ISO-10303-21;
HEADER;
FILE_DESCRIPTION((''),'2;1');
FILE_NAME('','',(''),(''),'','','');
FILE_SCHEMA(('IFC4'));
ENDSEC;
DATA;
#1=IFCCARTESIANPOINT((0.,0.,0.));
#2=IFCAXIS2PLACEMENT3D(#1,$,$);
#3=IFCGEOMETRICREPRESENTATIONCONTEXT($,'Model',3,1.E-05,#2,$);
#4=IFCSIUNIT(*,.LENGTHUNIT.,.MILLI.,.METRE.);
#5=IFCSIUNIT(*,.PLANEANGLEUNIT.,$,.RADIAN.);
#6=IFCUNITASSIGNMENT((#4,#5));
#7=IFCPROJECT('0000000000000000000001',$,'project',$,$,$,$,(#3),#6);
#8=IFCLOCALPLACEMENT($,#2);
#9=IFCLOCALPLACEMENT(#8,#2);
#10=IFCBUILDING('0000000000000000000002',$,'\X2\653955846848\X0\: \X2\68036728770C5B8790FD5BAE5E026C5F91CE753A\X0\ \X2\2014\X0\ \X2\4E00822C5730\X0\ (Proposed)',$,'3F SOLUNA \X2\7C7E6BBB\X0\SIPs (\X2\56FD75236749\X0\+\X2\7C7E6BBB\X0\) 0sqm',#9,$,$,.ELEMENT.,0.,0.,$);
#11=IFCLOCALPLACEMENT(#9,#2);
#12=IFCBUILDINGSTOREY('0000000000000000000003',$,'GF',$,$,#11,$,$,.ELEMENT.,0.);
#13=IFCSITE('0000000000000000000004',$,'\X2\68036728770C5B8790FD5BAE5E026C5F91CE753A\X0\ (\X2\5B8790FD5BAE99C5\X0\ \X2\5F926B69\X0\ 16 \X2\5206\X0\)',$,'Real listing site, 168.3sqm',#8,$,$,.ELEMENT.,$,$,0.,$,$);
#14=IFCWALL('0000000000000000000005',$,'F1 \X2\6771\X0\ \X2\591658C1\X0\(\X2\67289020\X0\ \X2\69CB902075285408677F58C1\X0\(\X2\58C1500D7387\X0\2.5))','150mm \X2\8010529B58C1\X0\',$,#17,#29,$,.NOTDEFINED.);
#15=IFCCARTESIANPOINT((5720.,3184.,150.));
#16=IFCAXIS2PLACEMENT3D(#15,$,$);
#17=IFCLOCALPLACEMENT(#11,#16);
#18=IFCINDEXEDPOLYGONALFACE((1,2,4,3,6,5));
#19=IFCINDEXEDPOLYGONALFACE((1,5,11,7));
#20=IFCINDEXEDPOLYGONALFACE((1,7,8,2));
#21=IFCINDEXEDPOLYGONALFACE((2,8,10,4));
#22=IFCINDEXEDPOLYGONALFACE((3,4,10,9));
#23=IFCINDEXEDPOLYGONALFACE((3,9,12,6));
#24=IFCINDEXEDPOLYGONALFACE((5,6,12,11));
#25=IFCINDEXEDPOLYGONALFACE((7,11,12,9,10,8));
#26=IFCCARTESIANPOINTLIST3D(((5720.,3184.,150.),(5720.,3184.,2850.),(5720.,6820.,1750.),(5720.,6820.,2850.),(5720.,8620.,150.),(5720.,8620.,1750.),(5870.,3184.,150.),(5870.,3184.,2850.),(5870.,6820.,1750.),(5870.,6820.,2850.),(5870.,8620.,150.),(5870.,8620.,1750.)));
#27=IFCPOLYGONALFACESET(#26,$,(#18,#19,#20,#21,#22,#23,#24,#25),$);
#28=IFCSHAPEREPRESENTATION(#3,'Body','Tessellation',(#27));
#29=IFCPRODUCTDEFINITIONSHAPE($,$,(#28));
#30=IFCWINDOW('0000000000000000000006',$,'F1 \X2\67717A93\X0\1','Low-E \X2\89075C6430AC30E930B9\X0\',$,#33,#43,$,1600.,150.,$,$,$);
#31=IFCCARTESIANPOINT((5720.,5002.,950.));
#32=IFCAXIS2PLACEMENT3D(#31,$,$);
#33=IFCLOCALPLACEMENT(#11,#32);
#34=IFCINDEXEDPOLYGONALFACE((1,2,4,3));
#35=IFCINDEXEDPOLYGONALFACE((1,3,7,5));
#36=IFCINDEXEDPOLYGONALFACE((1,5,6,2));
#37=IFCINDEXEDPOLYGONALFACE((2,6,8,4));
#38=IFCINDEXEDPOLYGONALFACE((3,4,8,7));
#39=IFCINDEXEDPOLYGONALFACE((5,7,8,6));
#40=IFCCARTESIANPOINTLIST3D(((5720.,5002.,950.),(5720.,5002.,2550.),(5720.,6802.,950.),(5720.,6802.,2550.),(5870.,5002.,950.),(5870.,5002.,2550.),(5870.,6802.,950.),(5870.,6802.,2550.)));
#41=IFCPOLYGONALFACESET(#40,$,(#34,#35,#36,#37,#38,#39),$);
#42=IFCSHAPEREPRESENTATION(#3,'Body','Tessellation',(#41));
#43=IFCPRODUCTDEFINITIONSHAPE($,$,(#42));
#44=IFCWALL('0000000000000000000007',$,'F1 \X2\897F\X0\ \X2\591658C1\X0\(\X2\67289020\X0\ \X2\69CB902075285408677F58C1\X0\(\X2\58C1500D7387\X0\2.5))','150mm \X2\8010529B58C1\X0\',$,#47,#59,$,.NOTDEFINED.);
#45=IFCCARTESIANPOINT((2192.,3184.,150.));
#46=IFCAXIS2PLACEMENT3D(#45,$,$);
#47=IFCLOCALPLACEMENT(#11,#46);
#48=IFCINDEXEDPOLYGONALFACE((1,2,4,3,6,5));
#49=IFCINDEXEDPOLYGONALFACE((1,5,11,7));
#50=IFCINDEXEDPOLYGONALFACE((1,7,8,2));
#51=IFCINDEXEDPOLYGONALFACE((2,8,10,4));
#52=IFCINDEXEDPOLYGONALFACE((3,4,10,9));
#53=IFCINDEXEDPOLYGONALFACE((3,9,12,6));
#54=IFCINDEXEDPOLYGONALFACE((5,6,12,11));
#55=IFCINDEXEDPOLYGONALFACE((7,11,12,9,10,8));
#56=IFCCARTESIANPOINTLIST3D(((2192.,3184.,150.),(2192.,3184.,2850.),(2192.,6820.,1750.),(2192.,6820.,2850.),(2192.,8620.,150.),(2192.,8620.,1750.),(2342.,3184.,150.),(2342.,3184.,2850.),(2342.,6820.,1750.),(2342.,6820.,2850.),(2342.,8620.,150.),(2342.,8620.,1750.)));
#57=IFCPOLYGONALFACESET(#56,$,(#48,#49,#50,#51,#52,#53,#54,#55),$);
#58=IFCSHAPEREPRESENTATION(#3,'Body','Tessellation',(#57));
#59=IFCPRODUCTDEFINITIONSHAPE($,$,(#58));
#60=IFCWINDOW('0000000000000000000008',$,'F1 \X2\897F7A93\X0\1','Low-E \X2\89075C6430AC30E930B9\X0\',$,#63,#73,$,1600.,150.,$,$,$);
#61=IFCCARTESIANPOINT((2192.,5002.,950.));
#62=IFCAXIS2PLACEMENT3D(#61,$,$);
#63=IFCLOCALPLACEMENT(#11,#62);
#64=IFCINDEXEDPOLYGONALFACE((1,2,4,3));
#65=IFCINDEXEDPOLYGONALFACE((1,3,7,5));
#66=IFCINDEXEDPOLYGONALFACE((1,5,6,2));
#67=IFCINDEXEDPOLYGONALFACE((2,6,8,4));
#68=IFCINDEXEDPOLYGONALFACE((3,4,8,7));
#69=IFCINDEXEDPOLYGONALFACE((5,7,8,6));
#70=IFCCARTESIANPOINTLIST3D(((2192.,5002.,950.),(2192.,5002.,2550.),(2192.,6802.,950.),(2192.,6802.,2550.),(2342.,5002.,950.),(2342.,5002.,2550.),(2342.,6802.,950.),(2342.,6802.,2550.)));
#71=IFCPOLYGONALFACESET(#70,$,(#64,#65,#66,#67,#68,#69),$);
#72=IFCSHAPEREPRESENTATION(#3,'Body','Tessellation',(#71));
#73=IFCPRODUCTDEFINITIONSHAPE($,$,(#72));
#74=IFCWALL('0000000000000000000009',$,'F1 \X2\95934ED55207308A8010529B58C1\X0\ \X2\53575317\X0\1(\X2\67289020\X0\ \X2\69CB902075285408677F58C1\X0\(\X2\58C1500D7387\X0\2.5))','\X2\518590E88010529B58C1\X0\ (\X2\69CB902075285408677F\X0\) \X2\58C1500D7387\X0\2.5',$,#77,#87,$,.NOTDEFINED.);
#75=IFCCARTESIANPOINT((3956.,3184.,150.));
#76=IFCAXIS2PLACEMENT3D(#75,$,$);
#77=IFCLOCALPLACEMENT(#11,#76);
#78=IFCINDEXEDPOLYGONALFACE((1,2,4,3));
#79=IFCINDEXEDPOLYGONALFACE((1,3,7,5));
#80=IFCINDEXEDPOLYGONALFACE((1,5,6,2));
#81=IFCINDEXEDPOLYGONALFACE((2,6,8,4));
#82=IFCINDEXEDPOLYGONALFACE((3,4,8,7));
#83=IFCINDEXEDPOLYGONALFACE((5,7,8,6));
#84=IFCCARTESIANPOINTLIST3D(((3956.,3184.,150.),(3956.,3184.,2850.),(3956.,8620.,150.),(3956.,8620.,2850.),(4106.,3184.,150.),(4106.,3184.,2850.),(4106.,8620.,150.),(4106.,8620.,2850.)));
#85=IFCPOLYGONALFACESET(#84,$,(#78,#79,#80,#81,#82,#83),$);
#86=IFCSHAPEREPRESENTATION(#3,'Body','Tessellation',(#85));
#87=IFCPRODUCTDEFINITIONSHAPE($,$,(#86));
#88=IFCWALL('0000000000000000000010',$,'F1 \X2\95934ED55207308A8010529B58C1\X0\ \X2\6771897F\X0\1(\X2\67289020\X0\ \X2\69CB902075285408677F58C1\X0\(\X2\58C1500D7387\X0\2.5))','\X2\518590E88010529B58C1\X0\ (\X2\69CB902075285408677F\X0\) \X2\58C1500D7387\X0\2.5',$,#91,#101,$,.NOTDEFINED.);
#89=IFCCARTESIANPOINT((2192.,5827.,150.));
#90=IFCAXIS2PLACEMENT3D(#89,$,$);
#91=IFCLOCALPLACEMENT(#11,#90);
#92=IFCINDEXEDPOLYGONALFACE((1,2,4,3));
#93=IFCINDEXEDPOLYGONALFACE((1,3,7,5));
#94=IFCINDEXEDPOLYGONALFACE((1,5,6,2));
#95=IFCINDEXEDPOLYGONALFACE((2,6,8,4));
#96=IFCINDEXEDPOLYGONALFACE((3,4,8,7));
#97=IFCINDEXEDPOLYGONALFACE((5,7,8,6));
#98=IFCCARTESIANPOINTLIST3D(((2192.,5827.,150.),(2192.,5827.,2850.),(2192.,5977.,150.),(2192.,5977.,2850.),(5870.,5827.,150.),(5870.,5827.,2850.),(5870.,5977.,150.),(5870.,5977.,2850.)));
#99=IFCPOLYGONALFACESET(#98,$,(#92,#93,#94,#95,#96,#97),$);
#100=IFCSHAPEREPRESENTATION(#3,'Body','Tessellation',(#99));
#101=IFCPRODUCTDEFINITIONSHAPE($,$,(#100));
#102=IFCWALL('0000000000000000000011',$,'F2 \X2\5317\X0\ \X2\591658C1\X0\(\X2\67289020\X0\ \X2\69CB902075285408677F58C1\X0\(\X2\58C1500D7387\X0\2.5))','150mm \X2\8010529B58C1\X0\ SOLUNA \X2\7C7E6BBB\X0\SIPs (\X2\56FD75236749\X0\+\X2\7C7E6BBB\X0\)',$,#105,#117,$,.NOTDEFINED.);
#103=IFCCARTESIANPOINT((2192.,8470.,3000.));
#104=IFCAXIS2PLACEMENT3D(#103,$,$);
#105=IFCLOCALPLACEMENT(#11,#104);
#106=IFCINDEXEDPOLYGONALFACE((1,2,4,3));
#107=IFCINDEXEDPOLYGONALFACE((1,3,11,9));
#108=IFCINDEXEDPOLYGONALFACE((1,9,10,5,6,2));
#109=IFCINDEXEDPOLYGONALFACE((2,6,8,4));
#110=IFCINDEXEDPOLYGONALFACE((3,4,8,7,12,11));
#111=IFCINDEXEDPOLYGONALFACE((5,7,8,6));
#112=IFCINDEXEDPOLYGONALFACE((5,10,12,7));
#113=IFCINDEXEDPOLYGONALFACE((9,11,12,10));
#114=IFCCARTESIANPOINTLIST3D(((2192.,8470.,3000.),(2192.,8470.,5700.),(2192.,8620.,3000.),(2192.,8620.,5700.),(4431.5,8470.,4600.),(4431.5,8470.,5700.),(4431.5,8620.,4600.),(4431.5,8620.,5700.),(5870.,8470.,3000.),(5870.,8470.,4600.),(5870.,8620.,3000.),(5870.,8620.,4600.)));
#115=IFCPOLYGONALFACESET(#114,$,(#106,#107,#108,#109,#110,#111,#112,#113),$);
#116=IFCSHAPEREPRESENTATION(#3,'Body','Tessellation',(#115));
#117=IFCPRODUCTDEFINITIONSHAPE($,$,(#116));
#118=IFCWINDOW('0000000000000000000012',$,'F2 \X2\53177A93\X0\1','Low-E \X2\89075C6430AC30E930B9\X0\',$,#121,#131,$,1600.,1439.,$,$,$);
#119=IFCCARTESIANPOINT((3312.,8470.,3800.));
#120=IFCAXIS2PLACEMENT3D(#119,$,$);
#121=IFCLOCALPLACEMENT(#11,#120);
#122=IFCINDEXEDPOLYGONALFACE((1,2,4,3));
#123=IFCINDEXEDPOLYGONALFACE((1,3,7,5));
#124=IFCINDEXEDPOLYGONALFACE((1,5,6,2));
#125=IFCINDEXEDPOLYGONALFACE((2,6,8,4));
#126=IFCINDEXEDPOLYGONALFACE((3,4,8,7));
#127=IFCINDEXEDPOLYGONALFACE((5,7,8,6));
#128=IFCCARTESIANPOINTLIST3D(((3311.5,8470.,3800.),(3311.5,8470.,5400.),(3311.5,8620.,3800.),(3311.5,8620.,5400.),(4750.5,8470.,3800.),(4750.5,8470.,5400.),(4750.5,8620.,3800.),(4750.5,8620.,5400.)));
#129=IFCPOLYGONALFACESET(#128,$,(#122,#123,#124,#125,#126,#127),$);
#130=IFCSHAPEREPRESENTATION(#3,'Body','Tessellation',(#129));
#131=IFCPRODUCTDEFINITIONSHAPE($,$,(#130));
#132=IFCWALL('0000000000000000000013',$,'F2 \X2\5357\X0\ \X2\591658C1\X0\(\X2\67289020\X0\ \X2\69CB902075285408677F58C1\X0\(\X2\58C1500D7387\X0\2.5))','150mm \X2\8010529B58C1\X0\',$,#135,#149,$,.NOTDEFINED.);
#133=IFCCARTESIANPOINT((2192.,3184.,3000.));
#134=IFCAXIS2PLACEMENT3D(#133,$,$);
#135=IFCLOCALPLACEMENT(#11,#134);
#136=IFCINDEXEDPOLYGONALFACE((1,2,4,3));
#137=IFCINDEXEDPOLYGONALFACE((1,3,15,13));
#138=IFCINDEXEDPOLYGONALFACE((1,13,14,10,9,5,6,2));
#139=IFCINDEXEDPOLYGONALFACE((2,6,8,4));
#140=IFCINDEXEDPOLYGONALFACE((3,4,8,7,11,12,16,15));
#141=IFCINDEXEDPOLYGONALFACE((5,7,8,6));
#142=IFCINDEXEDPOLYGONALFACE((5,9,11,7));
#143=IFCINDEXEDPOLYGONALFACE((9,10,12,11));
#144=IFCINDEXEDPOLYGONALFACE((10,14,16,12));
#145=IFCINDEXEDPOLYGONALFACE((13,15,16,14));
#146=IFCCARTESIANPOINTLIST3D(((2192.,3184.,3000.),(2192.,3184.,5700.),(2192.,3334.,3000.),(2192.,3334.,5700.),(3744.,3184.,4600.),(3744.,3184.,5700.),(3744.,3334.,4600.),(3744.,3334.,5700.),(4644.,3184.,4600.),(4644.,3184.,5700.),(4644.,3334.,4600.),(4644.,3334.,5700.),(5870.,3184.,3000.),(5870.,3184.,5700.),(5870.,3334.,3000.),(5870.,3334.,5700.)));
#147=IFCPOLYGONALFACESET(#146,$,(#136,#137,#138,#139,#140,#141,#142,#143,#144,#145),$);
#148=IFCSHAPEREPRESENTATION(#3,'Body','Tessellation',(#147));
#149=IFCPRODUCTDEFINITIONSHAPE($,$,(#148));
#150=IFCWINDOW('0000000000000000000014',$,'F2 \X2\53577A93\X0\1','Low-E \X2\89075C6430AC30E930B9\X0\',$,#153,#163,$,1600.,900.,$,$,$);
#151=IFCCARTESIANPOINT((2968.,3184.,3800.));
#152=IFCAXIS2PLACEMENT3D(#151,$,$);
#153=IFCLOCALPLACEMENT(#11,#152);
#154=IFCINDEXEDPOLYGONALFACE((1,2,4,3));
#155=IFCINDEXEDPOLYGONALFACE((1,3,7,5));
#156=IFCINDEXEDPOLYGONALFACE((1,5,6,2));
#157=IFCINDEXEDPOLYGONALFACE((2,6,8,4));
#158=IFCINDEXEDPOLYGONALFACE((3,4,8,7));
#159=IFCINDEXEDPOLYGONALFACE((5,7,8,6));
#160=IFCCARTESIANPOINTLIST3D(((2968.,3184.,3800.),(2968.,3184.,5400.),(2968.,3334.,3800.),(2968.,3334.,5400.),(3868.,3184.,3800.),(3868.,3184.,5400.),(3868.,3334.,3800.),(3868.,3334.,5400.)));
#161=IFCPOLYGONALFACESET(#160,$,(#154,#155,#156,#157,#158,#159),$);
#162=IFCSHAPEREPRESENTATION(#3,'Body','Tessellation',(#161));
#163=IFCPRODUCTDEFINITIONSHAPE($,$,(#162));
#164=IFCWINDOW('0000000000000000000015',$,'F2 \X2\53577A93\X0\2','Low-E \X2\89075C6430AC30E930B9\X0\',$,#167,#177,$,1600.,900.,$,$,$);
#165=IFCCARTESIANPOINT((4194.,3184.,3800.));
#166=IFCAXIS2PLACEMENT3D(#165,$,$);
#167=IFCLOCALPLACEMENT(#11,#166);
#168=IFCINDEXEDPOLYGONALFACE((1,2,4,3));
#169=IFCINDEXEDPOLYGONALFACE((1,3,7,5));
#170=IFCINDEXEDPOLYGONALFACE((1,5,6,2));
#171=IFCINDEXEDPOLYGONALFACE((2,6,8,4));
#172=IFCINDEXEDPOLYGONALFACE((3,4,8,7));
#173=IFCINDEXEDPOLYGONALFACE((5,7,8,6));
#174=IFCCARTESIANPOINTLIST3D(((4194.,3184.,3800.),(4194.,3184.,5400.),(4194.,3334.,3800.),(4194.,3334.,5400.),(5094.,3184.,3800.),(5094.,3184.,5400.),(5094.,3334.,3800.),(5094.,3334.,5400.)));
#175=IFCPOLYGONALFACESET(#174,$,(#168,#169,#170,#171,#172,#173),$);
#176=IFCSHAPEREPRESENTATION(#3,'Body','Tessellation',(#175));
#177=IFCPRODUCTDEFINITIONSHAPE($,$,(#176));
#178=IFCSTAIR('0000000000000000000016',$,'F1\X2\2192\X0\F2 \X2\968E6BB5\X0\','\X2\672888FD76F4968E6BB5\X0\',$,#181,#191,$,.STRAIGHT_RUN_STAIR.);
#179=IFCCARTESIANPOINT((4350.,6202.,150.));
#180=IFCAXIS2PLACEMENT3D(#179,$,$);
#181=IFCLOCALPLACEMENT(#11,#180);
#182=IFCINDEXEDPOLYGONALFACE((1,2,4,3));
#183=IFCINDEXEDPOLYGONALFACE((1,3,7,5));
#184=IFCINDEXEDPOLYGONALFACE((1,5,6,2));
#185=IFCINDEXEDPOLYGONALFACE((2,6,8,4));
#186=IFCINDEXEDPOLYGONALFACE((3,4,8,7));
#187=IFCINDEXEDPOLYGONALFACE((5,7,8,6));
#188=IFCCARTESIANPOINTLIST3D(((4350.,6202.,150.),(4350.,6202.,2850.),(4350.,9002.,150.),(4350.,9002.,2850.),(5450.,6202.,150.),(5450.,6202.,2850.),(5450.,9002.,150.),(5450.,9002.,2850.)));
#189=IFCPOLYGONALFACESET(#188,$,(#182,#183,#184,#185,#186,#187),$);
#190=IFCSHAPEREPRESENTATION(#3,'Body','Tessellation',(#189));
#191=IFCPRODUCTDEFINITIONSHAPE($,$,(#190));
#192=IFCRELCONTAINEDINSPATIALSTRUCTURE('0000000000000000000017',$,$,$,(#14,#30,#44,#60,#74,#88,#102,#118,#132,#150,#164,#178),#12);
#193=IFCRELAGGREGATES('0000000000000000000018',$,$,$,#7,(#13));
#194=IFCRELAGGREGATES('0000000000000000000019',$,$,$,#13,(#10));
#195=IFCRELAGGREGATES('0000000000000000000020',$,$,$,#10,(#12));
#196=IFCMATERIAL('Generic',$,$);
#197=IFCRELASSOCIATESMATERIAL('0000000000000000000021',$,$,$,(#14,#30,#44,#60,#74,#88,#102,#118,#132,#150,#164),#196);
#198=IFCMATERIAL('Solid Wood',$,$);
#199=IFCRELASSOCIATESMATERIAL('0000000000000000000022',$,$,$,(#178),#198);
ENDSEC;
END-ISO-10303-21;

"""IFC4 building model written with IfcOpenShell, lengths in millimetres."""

from ifc_helpers import new_model, si_unit, frame, frame_2d, origin, place, context, project, spatial, rectangle, extrude, material, element, fill, save


model = new_model("IFC4")

# Units and contexts
model_context = context("Model", 3, precision=1e-05, world=origin())
ifc_project = project(units=[si_unit("LENGTHUNIT", "METRE", prefix="MILLI"), si_unit("PLANEANGLEUNIT", "RADIAN")], contexts=[model_context])

# Site, building, storey
site_placement = place(None, origin())
site = spatial("IfcSite", under=ifc_project, at=site_placement, Name="栃木県宇都宮市江野町 (宇都宮駅 徒歩 16 分)", ObjectType="Real listing site, 168.3sqm", CompositionType="ELEMENT", RefElevation=0.0)
building_placement = place(site_placement, origin())
building = spatial("IfcBuilding", under=site, at=building_placement, Name="改善案: 栃木県宇都宮市江野町 — 一般地 (Proposed)", ObjectType="3F SOLUNA 籾殻SIPs (国産杉+籾殻) 0sqm", CompositionType="ELEMENT", ElevationOfRefHeight=0.0, ElevationOfTerrain=0.0)
storey_placement = place(building_placement, origin())
storey = spatial("IfcBuildingStorey", under=building, at=storey_placement, Name="GF", CompositionType="ELEMENT", Elevation=0.0)

# Shared definitions
ifc_material_1 = material(Name="Generic")

# Shared definitions
ifc_material_2 = material(Name="Solid Wood")

# Walls, openings, windows
wall_1_placement = place(storey_placement, frame((5720.0, 3184.0, 150.0)))
wall_1 = element("IfcWall", 1, at=wall_1_placement, inside=storey, material=ifc_material_1, Name="F1 東 外壁(木造 構造用合板壁(壁倍率2.5))", Description="150mm 耐力壁", PredefinedType="NOTDEFINED", context=model_context, shape_type="SweptSolid", body=[
    extrude(rectangle(XDim=150.0, YDim=5436.0, at=frame_2d((75.0, 2718.0))), frame((5720.0, 3184.0, 150.0)), (0.0, 0.0, 1.0), 2700.0),
])
opening_1_placement = place(storey_placement, frame((5720.0, 5002.0, 950.0)))
opening_1 = element("IfcOpeningElement", 2, at=opening_1_placement, cuts=wall_1, PredefinedType="NOTDEFINED", context=model_context, shape_type="SweptSolid", body=[
    extrude(rectangle(XDim=150.0, YDim=1800.0, at=frame_2d((75.0, 900.0))), frame((5720.0, 5002.0, 950.0)), (0.0, 0.0, 1.0), 1600.0),
])
window_1_placement = place(storey_placement, frame((5720.0, 5002.0, 950.0)))
window_1 = element("IfcWindow", 3, at=window_1_placement, inside=storey, material=ifc_material_1, Name="F1 東窓1", Description="Low-E 複層ガラス", OverallHeight=1600.0, OverallWidth=150.0, context=model_context, shape_type="SweptSolid", body=[
    extrude(rectangle(XDim=150.0, YDim=1800.0, at=frame_2d((75.0, 900.0))), frame((5720.0, 5002.0, 950.0)), (0.0, 0.0, 1.0), 1600.0),
])
fill(opening_1, window_1)
wall_2_placement = place(storey_placement, frame((2192.0, 3184.0, 150.0)))
wall_2 = element("IfcWall", 4, at=wall_2_placement, inside=storey, material=ifc_material_1, Name="F1 西 外壁(木造 構造用合板壁(壁倍率2.5))", Description="150mm 耐力壁", PredefinedType="NOTDEFINED", context=model_context, shape_type="SweptSolid", body=[
    extrude(rectangle(XDim=150.0, YDim=5436.0, at=frame_2d((75.0, 2718.0))), frame((2192.0, 3184.0, 150.0)), (0.0, 0.0, 1.0), 2700.0),
])
opening_2_placement = place(storey_placement, frame((2192.0, 5002.0, 950.0)))
opening_2 = element("IfcOpeningElement", 5, at=opening_2_placement, cuts=wall_2, PredefinedType="NOTDEFINED", context=model_context, shape_type="SweptSolid", body=[
    extrude(rectangle(XDim=150.0, YDim=1800.0, at=frame_2d((75.0, 900.0))), frame((2192.0, 5002.0, 950.0)), (0.0, 0.0, 1.0), 1600.0),
])
window_2_placement = place(storey_placement, frame((2192.0, 5002.0, 950.0)))
window_2 = element("IfcWindow", 6, at=window_2_placement, inside=storey, material=ifc_material_1, Name="F1 西窓1", Description="Low-E 複層ガラス", OverallHeight=1600.0, OverallWidth=150.0, context=model_context, shape_type="SweptSolid", body=[
    extrude(rectangle(XDim=150.0, YDim=1800.0, at=frame_2d((75.0, 900.0))), frame((2192.0, 5002.0, 950.0)), (0.0, 0.0, 1.0), 1600.0),
])
fill(opening_2, window_2)

# Walls
wall_3_placement = place(storey_placement, frame((3956.0, 3184.0, 150.0)))
element("IfcWall", 7, at=wall_3_placement, inside=storey, material=ifc_material_1, Name="F1 間仕切り耐力壁 南北1(木造 構造用合板壁(壁倍率2.5))", Description="内部耐力壁 (構造用合板) 壁倍率2.5", PredefinedType="NOTDEFINED", context=model_context, shape_type="SweptSolid", body=[
    extrude(rectangle(XDim=150.0, YDim=5436.0, at=frame_2d((75.0, 2718.0))), frame((3956.0, 3184.0, 150.0)), (0.0, 0.0, 1.0), 2700.0),
])
wall_4_placement = place(storey_placement, frame((2192.0, 5827.0, 150.0)))
element("IfcWall", 8, at=wall_4_placement, inside=storey, material=ifc_material_1, Name="F1 間仕切り耐力壁 東西1(木造 構造用合板壁(壁倍率2.5))", Description="内部耐力壁 (構造用合板) 壁倍率2.5", PredefinedType="NOTDEFINED", context=model_context, shape_type="SweptSolid", body=[
    extrude(rectangle(XDim=3678.0, YDim=150.0, at=frame_2d((1839.0, 75.0))), frame((2192.0, 5827.0, 150.0)), (0.0, 0.0, 1.0), 2700.0),
])

# Wall, opening, window
wall_5_placement = place(storey_placement, frame((2192.0, 8470.0, 3000.0)))
wall_5 = element("IfcWall", 9, at=wall_5_placement, inside=storey, material=ifc_material_1, Name="F2 北 外壁(木造 構造用合板壁(壁倍率2.5))", Description="150mm 耐力壁 SOLUNA 籾殻SIPs (国産杉+籾殻)", PredefinedType="NOTDEFINED", context=model_context, shape_type="SweptSolid", body=[
    extrude(rectangle(XDim=3678.0, YDim=150.0, at=frame_2d((1839.0, 75.0))), frame((2192.0, 8470.0, 3000.0)), (0.0, 0.0, 1.0), 2700.0),
])
opening_3_placement = place(storey_placement, frame((3312.0, 8470.0, 3800.0)))
opening_3 = element("IfcOpeningElement", 10, at=opening_3_placement, cuts=wall_5, PredefinedType="NOTDEFINED", context=model_context, shape_type="SweptSolid", body=[
    extrude(rectangle(XDim=1439.0, YDim=150.0, at=frame_2d((719.0, 75.0))), frame((3312.0, 8470.0, 3800.0)), (0.0, 0.0, 1.0), 1600.0),
])
window_3_placement = place(storey_placement, frame((3312.0, 8470.0, 3800.0)))
window_3 = element("IfcWindow", 11, at=window_3_placement, inside=storey, material=ifc_material_1, Name="F2 北窓1", Description="Low-E 複層ガラス", OverallHeight=1600.0, OverallWidth=1439.0, context=model_context, shape_type="SweptSolid", body=[
    extrude(rectangle(XDim=1439.0, YDim=150.0, at=frame_2d((719.0, 75.0))), frame((3312.0, 8470.0, 3800.0)), (0.0, 0.0, 1.0), 1600.0),
])
fill(opening_3, window_3)

# Wall, openings, windows
wall_6_placement = place(storey_placement, frame((2192.0, 3184.0, 3000.0)))
wall_6 = element("IfcWall", 12, at=wall_6_placement, inside=storey, material=ifc_material_1, Name="F2 南 外壁(木造 構造用合板壁(壁倍率2.5))", Description="150mm 耐力壁", PredefinedType="NOTDEFINED", context=model_context, shape_type="SweptSolid", body=[
    extrude(rectangle(XDim=3678.0, YDim=150.0, at=frame_2d((1839.0, 75.0))), frame((2192.0, 3184.0, 3000.0)), (0.0, 0.0, 1.0), 2700.0),
])
opening_4_placement = place(storey_placement, frame((2968.0, 3184.0, 3800.0)))
opening_4 = element("IfcOpeningElement", 13, at=opening_4_placement, cuts=wall_6, PredefinedType="NOTDEFINED", context=model_context, shape_type="SweptSolid", body=[
    extrude(rectangle(XDim=900.0, YDim=150.0, at=frame_2d((450.0, 75.0))), frame((2968.0, 3184.0, 3800.0)), (0.0, 0.0, 1.0), 1600.0),
])
opening_5_placement = place(storey_placement, frame((4194.0, 3184.0, 3800.0)))
opening_5 = element("IfcOpeningElement", 14, at=opening_5_placement, cuts=wall_6, PredefinedType="NOTDEFINED", context=model_context, shape_type="SweptSolid", body=[
    extrude(rectangle(XDim=900.0, YDim=150.0, at=frame_2d((450.0, 75.0))), frame((4194.0, 3184.0, 3800.0)), (0.0, 0.0, 1.0), 1600.0),
])
window_4_placement = place(storey_placement, frame((2968.0, 3184.0, 3800.0)))
window_4 = element("IfcWindow", 15, at=window_4_placement, inside=storey, material=ifc_material_1, Name="F2 南窓1", Description="Low-E 複層ガラス", OverallHeight=1600.0, OverallWidth=900.0, context=model_context, shape_type="SweptSolid", body=[
    extrude(rectangle(XDim=900.0, YDim=150.0, at=frame_2d((450.0, 75.0))), frame((2968.0, 3184.0, 3800.0)), (0.0, 0.0, 1.0), 1600.0),
])
fill(opening_4, window_4)
window_5_placement = place(storey_placement, frame((4194.0, 3184.0, 3800.0)))
window_5 = element("IfcWindow", 16, at=window_5_placement, inside=storey, material=ifc_material_1, Name="F2 南窓2", Description="Low-E 複層ガラス", OverallHeight=1600.0, OverallWidth=900.0, context=model_context, shape_type="SweptSolid", body=[
    extrude(rectangle(XDim=900.0, YDim=150.0, at=frame_2d((450.0, 75.0))), frame((4194.0, 3184.0, 3800.0)), (0.0, 0.0, 1.0), 1600.0),
])
fill(opening_5, window_5)

# Stair
stair_placement = place(storey_placement, frame((4350.0, 6202.0, 150.0)))
element("IfcStair", 17, at=stair_placement, inside=storey, material=ifc_material_2, Name="F1→F2 階段", Description="木製直階段", PredefinedType="STRAIGHT_RUN_STAIR", context=model_context, shape_type="SweptSolid", body=[
    extrude(rectangle(XDim=1100.0, YDim=2800.0, at=frame_2d((550.0, 1400.0))), frame((4350.0, 6202.0, 150.0)), (0.0, 0.0, 1.0), 2700.0),
])

save(model, "model.ifc")
